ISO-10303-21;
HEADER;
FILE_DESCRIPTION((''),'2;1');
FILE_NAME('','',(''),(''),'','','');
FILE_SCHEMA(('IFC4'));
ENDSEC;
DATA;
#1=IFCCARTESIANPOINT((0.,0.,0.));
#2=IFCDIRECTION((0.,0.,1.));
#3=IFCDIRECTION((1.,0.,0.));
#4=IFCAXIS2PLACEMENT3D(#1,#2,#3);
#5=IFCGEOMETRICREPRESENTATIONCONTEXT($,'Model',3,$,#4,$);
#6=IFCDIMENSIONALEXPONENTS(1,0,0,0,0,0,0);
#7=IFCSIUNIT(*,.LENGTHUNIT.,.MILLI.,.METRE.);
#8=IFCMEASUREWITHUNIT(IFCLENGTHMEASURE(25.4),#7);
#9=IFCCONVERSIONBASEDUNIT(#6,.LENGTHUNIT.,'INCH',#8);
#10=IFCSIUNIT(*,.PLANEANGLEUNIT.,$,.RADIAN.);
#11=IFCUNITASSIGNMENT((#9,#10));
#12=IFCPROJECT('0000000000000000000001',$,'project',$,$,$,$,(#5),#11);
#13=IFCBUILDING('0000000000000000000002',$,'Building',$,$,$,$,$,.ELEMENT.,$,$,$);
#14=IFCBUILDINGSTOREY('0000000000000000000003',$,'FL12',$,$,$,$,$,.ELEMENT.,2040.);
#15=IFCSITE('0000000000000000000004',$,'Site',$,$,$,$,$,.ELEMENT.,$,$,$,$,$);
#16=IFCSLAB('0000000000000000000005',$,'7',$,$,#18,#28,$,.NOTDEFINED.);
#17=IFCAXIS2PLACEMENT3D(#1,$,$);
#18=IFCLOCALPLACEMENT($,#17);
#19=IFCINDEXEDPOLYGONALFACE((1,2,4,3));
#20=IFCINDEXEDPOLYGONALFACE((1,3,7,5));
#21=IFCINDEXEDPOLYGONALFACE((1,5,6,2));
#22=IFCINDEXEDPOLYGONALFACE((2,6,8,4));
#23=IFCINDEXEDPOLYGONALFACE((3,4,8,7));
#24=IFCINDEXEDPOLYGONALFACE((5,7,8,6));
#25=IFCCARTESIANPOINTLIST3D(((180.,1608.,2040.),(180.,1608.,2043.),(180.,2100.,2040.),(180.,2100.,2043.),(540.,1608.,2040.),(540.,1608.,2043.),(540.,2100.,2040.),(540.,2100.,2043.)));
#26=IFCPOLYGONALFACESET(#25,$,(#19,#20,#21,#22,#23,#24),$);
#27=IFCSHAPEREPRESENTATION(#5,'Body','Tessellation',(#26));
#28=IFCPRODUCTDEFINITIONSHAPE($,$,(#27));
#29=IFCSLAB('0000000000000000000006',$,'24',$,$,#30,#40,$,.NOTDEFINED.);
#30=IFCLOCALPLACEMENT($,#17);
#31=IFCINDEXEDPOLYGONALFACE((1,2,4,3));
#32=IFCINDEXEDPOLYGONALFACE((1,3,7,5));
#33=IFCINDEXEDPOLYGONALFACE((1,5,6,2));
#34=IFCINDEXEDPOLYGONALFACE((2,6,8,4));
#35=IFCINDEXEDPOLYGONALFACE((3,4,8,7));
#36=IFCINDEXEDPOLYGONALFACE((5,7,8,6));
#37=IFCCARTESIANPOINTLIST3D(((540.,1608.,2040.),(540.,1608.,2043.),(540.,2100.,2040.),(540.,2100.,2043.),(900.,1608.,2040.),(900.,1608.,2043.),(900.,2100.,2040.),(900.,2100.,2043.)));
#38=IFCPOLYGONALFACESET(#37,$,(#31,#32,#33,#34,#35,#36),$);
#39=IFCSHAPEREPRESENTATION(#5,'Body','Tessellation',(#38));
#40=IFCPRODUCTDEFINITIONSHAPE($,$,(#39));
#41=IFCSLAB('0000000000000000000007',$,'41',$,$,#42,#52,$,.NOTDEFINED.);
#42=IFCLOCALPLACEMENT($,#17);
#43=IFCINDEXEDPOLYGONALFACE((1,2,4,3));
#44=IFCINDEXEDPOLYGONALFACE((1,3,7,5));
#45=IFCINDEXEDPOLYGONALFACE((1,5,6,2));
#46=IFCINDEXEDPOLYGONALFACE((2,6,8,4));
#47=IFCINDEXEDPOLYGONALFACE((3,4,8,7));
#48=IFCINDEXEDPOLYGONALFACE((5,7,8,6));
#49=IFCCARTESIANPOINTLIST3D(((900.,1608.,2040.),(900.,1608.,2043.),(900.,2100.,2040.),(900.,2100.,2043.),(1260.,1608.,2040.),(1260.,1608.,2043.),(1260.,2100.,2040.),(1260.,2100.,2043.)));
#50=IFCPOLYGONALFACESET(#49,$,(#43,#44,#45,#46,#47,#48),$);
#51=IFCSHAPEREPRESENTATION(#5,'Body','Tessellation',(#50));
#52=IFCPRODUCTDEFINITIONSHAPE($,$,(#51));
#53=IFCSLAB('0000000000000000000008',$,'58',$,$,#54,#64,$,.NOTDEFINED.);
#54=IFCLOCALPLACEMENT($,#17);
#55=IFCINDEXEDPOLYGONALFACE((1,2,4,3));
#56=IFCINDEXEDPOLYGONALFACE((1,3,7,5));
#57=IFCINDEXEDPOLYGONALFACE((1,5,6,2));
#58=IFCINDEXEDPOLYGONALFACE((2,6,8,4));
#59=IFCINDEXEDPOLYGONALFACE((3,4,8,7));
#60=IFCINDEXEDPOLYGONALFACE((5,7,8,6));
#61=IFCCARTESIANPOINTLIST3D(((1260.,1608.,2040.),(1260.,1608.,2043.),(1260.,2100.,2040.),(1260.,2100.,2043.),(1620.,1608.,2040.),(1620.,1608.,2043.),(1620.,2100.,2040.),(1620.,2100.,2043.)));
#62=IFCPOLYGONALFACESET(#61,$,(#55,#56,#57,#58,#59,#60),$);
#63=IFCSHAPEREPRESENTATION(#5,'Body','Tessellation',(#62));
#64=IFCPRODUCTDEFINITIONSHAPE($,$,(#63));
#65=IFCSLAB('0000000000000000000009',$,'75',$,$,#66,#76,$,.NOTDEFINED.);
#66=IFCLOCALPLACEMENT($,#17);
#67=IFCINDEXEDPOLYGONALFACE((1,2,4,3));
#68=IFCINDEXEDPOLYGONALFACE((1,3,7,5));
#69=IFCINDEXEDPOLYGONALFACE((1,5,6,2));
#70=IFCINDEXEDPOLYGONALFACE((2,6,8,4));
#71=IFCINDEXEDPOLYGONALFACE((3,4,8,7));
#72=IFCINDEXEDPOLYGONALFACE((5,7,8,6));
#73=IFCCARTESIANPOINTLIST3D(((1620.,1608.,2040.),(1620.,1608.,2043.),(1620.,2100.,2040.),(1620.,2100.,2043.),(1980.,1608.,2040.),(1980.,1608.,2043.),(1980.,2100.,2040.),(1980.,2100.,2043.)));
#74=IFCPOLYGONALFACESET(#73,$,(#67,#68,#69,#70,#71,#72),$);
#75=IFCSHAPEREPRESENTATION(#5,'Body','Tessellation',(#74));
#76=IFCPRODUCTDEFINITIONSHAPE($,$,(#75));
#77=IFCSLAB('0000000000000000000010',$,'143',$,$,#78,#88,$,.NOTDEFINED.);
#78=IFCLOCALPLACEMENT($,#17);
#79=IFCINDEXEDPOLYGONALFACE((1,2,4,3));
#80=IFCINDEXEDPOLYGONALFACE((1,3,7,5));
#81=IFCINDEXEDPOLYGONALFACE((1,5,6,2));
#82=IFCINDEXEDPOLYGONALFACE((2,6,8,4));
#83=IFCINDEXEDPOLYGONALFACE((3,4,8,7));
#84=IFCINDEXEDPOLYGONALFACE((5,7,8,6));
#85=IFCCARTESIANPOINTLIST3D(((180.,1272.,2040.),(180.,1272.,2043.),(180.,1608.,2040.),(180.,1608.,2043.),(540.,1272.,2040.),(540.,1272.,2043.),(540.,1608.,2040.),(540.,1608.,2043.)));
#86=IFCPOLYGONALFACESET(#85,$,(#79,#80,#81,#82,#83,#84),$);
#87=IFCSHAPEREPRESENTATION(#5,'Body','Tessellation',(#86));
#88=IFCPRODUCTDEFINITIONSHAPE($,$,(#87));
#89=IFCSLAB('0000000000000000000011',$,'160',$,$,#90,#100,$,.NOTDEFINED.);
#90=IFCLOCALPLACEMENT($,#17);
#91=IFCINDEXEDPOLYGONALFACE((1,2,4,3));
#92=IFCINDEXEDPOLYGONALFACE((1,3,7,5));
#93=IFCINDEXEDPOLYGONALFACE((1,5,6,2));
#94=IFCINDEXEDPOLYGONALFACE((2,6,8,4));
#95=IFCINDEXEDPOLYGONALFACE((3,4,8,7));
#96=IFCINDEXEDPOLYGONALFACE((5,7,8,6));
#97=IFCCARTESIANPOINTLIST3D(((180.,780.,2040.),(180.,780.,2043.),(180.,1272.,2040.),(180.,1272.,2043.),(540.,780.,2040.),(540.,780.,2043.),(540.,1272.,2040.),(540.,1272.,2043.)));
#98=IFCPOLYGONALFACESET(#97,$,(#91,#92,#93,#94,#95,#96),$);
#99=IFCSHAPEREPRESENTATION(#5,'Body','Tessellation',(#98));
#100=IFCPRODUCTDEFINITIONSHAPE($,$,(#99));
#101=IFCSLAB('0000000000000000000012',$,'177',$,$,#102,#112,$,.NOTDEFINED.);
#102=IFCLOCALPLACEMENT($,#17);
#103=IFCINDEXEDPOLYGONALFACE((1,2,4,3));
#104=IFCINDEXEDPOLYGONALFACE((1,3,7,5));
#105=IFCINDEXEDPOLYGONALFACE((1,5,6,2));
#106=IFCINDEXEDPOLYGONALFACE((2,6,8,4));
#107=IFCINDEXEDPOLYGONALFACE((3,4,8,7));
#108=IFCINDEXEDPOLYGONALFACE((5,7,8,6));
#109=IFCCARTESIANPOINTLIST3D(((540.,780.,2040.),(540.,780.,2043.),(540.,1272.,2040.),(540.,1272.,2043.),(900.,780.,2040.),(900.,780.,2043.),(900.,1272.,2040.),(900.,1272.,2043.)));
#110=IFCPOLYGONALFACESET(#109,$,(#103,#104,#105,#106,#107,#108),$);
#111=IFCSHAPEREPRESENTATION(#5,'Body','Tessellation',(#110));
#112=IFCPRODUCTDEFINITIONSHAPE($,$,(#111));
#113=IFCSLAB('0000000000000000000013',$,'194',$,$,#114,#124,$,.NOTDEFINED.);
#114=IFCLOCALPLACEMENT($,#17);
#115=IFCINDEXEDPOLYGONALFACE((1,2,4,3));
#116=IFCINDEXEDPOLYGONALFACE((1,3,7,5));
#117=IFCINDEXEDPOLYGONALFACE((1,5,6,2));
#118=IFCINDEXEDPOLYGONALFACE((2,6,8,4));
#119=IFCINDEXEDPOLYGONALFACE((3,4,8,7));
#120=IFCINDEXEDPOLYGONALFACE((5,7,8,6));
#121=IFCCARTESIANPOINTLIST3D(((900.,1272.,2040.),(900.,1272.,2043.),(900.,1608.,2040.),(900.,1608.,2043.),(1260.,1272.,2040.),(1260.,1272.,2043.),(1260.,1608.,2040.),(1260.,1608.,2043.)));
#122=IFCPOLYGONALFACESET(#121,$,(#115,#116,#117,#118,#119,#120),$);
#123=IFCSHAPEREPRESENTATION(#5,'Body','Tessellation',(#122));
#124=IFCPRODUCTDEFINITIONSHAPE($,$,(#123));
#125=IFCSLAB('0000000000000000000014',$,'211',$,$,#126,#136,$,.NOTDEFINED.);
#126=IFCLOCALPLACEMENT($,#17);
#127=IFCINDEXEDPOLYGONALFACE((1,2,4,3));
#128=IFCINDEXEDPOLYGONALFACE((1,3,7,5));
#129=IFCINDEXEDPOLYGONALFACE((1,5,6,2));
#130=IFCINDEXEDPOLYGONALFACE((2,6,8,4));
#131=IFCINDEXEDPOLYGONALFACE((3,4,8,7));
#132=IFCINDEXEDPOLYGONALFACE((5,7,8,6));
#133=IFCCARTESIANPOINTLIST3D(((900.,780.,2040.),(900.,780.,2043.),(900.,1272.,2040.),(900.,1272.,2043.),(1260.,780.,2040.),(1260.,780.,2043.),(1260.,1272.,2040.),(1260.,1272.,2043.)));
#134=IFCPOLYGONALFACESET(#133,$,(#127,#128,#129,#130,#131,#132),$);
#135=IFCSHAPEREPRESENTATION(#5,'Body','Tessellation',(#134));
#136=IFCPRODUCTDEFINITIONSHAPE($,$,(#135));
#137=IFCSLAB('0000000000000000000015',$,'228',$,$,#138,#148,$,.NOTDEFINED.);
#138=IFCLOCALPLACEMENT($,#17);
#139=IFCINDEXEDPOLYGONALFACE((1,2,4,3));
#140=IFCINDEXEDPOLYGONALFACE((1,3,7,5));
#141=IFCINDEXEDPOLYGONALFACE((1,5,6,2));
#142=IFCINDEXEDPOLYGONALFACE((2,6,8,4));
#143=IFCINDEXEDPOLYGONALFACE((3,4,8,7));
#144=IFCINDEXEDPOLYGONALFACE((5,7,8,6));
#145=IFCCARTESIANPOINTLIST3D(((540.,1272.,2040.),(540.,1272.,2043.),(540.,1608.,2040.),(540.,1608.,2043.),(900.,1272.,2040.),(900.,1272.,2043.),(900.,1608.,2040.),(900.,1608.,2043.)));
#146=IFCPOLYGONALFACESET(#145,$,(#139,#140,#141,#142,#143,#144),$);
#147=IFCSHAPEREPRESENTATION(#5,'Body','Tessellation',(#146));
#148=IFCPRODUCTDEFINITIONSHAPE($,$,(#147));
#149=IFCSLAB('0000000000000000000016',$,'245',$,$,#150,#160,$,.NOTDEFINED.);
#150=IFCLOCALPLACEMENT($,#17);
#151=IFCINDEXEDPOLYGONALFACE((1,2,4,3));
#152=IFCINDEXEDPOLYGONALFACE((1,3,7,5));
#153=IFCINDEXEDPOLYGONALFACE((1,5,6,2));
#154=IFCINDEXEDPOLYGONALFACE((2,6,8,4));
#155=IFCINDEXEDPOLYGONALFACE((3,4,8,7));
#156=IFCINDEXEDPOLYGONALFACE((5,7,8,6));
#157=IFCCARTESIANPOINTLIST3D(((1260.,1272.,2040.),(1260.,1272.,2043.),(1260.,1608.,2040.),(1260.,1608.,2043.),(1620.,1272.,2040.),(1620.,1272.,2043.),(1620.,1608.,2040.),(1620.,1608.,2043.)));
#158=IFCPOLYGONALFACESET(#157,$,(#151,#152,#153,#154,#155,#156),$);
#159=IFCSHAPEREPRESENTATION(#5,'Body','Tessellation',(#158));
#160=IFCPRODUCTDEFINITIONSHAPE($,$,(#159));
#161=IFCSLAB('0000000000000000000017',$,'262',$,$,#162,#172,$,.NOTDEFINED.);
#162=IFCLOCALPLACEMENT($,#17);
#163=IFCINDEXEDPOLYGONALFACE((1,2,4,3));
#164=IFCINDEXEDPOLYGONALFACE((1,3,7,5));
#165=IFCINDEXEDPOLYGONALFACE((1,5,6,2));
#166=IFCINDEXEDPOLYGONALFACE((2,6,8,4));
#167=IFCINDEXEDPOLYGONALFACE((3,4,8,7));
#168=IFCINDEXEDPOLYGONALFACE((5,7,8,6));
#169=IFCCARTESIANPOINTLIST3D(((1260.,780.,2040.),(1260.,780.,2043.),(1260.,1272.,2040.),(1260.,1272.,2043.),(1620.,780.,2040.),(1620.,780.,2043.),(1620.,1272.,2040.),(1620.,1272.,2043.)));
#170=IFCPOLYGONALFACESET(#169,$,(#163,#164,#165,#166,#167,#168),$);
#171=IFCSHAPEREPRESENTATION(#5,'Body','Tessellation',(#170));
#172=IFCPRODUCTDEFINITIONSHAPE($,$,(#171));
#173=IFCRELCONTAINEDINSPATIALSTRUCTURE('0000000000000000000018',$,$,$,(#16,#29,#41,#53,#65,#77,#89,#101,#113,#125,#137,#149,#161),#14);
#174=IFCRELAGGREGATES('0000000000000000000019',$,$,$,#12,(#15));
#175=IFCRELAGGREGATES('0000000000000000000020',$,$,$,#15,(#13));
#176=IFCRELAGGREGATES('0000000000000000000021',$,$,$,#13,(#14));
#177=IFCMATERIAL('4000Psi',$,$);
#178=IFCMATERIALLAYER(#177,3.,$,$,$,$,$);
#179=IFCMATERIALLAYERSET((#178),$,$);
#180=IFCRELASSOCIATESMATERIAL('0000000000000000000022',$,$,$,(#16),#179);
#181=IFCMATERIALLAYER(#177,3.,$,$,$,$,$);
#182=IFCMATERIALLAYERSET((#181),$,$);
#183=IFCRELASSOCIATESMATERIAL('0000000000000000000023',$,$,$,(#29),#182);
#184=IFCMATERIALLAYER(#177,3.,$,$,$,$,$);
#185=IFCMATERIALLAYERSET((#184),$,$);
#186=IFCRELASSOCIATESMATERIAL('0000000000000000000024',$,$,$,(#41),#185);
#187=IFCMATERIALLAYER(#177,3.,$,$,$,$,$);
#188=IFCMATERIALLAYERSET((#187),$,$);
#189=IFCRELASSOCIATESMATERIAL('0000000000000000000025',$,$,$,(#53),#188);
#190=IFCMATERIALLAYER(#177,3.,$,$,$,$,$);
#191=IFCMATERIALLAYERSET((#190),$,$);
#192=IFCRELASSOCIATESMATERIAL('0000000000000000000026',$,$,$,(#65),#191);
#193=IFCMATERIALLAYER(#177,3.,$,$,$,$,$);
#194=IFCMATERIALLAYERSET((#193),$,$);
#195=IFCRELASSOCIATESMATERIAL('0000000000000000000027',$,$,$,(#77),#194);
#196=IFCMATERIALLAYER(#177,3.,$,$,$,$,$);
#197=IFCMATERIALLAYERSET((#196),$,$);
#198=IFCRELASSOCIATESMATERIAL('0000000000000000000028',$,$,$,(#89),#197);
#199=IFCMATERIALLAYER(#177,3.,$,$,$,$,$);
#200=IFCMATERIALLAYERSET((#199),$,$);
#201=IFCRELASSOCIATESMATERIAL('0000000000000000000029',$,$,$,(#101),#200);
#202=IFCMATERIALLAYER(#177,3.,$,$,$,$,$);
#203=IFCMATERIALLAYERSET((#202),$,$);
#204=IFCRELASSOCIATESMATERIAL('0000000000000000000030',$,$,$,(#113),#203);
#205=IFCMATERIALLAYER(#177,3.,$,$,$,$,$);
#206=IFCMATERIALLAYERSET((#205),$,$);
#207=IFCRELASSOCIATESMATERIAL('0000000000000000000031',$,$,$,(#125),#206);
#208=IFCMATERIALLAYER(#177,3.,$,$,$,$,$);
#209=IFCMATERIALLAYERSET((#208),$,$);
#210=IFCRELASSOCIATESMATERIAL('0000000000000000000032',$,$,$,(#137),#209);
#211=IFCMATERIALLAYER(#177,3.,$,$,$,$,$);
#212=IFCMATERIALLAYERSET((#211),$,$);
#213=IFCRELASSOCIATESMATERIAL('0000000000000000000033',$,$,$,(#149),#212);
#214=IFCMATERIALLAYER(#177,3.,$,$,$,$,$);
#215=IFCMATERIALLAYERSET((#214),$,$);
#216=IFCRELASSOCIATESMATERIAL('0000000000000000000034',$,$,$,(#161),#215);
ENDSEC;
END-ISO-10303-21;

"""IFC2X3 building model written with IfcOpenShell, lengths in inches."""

from ifc_helpers import new_model, entity, si_unit, converted_unit, frame, origin_with_axes, place, context, project, spatial, polyline, outline, extrude, material, layer, layer_set, layer_usage, element, save


model = new_model("IFC2X3")

# Units and contexts
model_context = context("Model", 3, world=origin_with_axes())
ifc_project = project(units=[converted_unit("LENGTHUNIT", "INCH", entity("IfcLengthMeasure", 25.4), si_unit("LENGTHUNIT", "METRE", prefix="MILLI"), dimensions=[1, 0, 0, 0, 0, 0, 0]), si_unit("PLANEANGLEUNIT", "RADIAN")], contexts=[model_context])

# Site, building, storey
site = spatial("IfcSite", under=ifc_project, Name="Site", CompositionType="ELEMENT")
building = spatial("IfcBuilding", under=site, Name="Building", CompositionType="ELEMENT")
storey = spatial("IfcBuildingStorey", under=building, Name="FL12", CompositionType="ELEMENT", Elevation=2040.0)

# Slabs
ifc_material_1 = material(Name="4000Psi")
ifc_layer_1 = layer(ifc_material_1, 3.0)
ifc_layer_set_1 = layer_set([ifc_layer_1])
ifc_layer_usage_1 = layer_usage(ifc_layer_set_1, "AXIS2", "POSITIVE", -3.0)
slab_1_placement = place(None, frame((180.0, 1608.0, 2040.0), z_axis=(0.0, 0.0, 1.0), x_axis=(1.0, 0.0, 0.0)))
element("IfcSlab", 1, at=slab_1_placement, inside=storey, material=ifc_layer_usage_1, Name="7", PredefinedType="NOTDEFINED", context=model_context, shape_type="SweptSolid", body=[
    extrude(outline(polyline([(0.0, 0.0), (360.0, 0.0), (360.0, 492.0), (0.0, 492.0), (0.0, 0.0)])), origin_with_axes(), (0.0, 0.0, 1.0), 3.0),
])
ifc_layer_2 = layer(ifc_material_1, 3.0)
ifc_layer_set_2 = layer_set([ifc_layer_2])
ifc_layer_usage_2 = layer_usage(ifc_layer_set_2, "AXIS2", "POSITIVE", -3.0)
slab_2_placement = place(None, frame((540.0, 1608.0, 2040.0), z_axis=(0.0, 0.0, 1.0), x_axis=(1.0, 0.0, 0.0)))
element("IfcSlab", 2, at=slab_2_placement, inside=storey, material=ifc_layer_usage_2, Name="24", PredefinedType="NOTDEFINED", context=model_context, shape_type="SweptSolid", body=[
    extrude(outline(polyline([(0.0, 0.0), (360.0, 0.0), (360.0, 492.0), (0.0, 492.0), (0.0, 0.0)])), origin_with_axes(), (0.0, 0.0, 1.0), 3.0),
])
ifc_layer_3 = layer(ifc_material_1, 3.0)
ifc_layer_set_3 = layer_set([ifc_layer_3])
ifc_layer_usage_3 = layer_usage(ifc_layer_set_3, "AXIS2", "POSITIVE", -3.0)
slab_3_placement = place(None, frame((900.0, 1608.0, 2040.0), z_axis=(0.0, 0.0, 1.0), x_axis=(1.0, 0.0, 0.0)))
element("IfcSlab", 3, at=slab_3_placement, inside=storey, material=ifc_layer_usage_3, Name="41", PredefinedType="NOTDEFINED", context=model_context, shape_type="SweptSolid", body=[
    extrude(outline(polyline([(0.0, 0.0), (360.0, 0.0), (360.0, 492.0), (0.0, 492.0), (0.0, 0.0)])), origin_with_axes(), (0.0, 0.0, 1.0), 3.0),
])
ifc_layer_4 = layer(ifc_material_1, 3.0)
ifc_layer_set_4 = layer_set([ifc_layer_4])
ifc_layer_usage_4 = layer_usage(ifc_layer_set_4, "AXIS2", "POSITIVE", -3.0)
slab_4_placement = place(None, frame((1260.0, 1608.0, 2040.0), z_axis=(0.0, 0.0, 1.0), x_axis=(1.0, 0.0, 0.0)))
element("IfcSlab", 4, at=slab_4_placement, inside=storey, material=ifc_layer_usage_4, Name="58", PredefinedType="NOTDEFINED", context=model_context, shape_type="SweptSolid", body=[
    extrude(outline(polyline([(0.0, 0.0), (360.0, 0.0), (360.0, 492.0), (0.0, 492.0), (0.0, 0.0)])), origin_with_axes(), (0.0, 0.0, 1.0), 3.0),
])
ifc_layer_5 = layer(ifc_material_1, 3.0)
ifc_layer_set_5 = layer_set([ifc_layer_5])
ifc_layer_usage_5 = layer_usage(ifc_layer_set_5, "AXIS2", "POSITIVE", -3.0)
slab_5_placement = place(None, frame((1620.0, 1608.0, 2040.0), z_axis=(0.0, 0.0, 1.0), x_axis=(1.0, 0.0, 0.0)))
element("IfcSlab", 5, at=slab_5_placement, inside=storey, material=ifc_layer_usage_5, Name="75", PredefinedType="NOTDEFINED", context=model_context, shape_type="SweptSolid", body=[
    extrude(outline(polyline([(0.0, 0.0), (360.0, 0.0), (360.0, 492.0), (0.0, 492.0), (0.0, 0.0)])), origin_with_axes(), (0.0, 0.0, 1.0), 3.0),
])
ifc_layer_6 = layer(ifc_material_1, 3.0)
ifc_layer_set_6 = layer_set([ifc_layer_6])
ifc_layer_usage_6 = layer_usage(ifc_layer_set_6, "AXIS2", "POSITIVE", -3.0)
slab_6_placement = place(None, frame((180.0, 1272.0, 2040.0), z_axis=(0.0, 0.0, 1.0), x_axis=(1.0, 0.0, 0.0)))
element("IfcSlab", 6, at=slab_6_placement, inside=storey, material=ifc_layer_usage_6, Name="143", PredefinedType="NOTDEFINED", context=model_context, shape_type="SweptSolid", body=[
    extrude(outline(polyline([(0.0, 0.0), (360.0, 0.0), (360.0, 336.0), (0.0, 336.0), (0.0, 0.0)])), origin_with_axes(), (0.0, 0.0, 1.0), 3.0),
])
ifc_layer_7 = layer(ifc_material_1, 3.0)
ifc_layer_set_7 = layer_set([ifc_layer_7])
ifc_layer_usage_7 = layer_usage(ifc_layer_set_7, "AXIS2", "POSITIVE", -3.0)
slab_7_placement = place(None, frame((180.0, 780.0, 2040.0), z_axis=(0.0, 0.0, 1.0), x_axis=(1.0, 0.0, 0.0)))
element("IfcSlab", 7, at=slab_7_placement, inside=storey, material=ifc_layer_usage_7, Name="160", PredefinedType="NOTDEFINED", context=model_context, shape_type="SweptSolid", body=[
    extrude(outline(polyline([(0.0, 0.0), (360.0, 0.0), (360.0, 492.0), (0.0, 492.0), (0.0, 0.0)])), origin_with_axes(), (0.0, 0.0, 1.0), 3.0),
])
ifc_layer_8 = layer(ifc_material_1, 3.0)
ifc_layer_set_8 = layer_set([ifc_layer_8])
ifc_layer_usage_8 = layer_usage(ifc_layer_set_8, "AXIS2", "POSITIVE", -3.0)
slab_8_placement = place(None, frame((540.0, 780.0, 2040.0), z_axis=(0.0, 0.0, 1.0), x_axis=(1.0, 0.0, 0.0)))
element("IfcSlab", 8, at=slab_8_placement, inside=storey, material=ifc_layer_usage_8, Name="177", PredefinedType="NOTDEFINED", context=model_context, shape_type="SweptSolid", body=[
    extrude(outline(polyline([(0.0, 0.0), (360.0, 0.0), (360.0, 492.0), (0.0, 492.0), (0.0, 0.0)])), origin_with_axes(), (0.0, 0.0, 1.0), 3.0),
])
ifc_layer_9 = layer(ifc_material_1, 3.0)
ifc_layer_set_9 = layer_set([ifc_layer_9])
ifc_layer_usage_9 = layer_usage(ifc_layer_set_9, "AXIS2", "POSITIVE", -3.0)
slab_9_placement = place(None, frame((900.0, 1272.0, 2040.0), z_axis=(0.0, 0.0, 1.0), x_axis=(1.0, 0.0, 0.0)))
element("IfcSlab", 9, at=slab_9_placement, inside=storey, material=ifc_layer_usage_9, Name="194", PredefinedType="NOTDEFINED", context=model_context, shape_type="SweptSolid", body=[
    extrude(outline(polyline([(0.0, 0.0), (360.0, 0.0), (360.0, 336.0), (0.0, 336.0), (0.0, 0.0)])), origin_with_axes(), (0.0, 0.0, 1.0), 3.0),
])
ifc_layer_10 = layer(ifc_material_1, 3.0)
ifc_layer_set_10 = layer_set([ifc_layer_10])
ifc_layer_usage_10 = layer_usage(ifc_layer_set_10, "AXIS2", "POSITIVE", -3.0)
slab_10_placement = place(None, frame((900.0, 780.0, 2040.0), z_axis=(0.0, 0.0, 1.0), x_axis=(1.0, 0.0, 0.0)))
element("IfcSlab", 10, at=slab_10_placement, inside=storey, material=ifc_layer_usage_10, Name="211", PredefinedType="NOTDEFINED", context=model_context, shape_type="SweptSolid", body=[
    extrude(outline(polyline([(0.0, 0.0), (360.0, 0.0), (360.0, 492.0), (0.0, 492.0), (0.0, 0.0)])), origin_with_axes(), (0.0, 0.0, 1.0), 3.0),
])
ifc_layer_11 = layer(ifc_material_1, 3.0)
ifc_layer_set_11 = layer_set([ifc_layer_11])
ifc_layer_usage_11 = layer_usage(ifc_layer_set_11, "AXIS2", "POSITIVE", -3.0)
slab_11_placement = place(None, frame((540.0, 1272.0, 2040.0), z_axis=(0.0, 0.0, 1.0), x_axis=(1.0, 0.0, 0.0)))
element("IfcSlab", 11, at=slab_11_placement, inside=storey, material=ifc_layer_usage_11, Name="228", PredefinedType="NOTDEFINED", context=model_context, shape_type="SweptSolid", body=[
    extrude(outline(polyline([(0.0, 0.0), (360.0, 0.0), (360.0, 336.0), (0.0, 336.0), (0.0, 0.0)])), origin_with_axes(), (0.0, 0.0, 1.0), 3.0),
])
ifc_layer_12 = layer(ifc_material_1, 3.0)
ifc_layer_set_12 = layer_set([ifc_layer_12])
ifc_layer_usage_12 = layer_usage(ifc_layer_set_12, "AXIS2", "POSITIVE", -3.0)
slab_12_placement = place(None, frame((1260.0, 1272.0, 2040.0), z_axis=(0.0, 0.0, 1.0), x_axis=(1.0, 0.0, 0.0)))
element("IfcSlab", 12, at=slab_12_placement, inside=storey, material=ifc_layer_usage_12, Name="245", PredefinedType="NOTDEFINED", context=model_context, shape_type="SweptSolid", body=[
    extrude(outline(polyline([(0.0, 0.0), (360.0, 0.0), (360.0, 336.0), (0.0, 336.0), (0.0, 0.0)])), origin_with_axes(), (0.0, 0.0, 1.0), 3.0),
])
ifc_layer_13 = layer(ifc_material_1, 3.0)
ifc_layer_set_13 = layer_set([ifc_layer_13])
ifc_layer_usage_13 = layer_usage(ifc_layer_set_13, "AXIS2", "POSITIVE", -3.0)
slab_13_placement = place(None, frame((1260.0, 780.0, 2040.0), z_axis=(0.0, 0.0, 1.0), x_axis=(1.0, 0.0, 0.0)))
element("IfcSlab", 13, at=slab_13_placement, inside=storey, material=ifc_layer_usage_13, Name="262", PredefinedType="NOTDEFINED", context=model_context, shape_type="SweptSolid", body=[
    extrude(outline(polyline([(0.0, 0.0), (360.0, 0.0), (360.0, 492.0), (0.0, 492.0), (0.0, 0.0)])), origin_with_axes(), (0.0, 0.0, 1.0), 3.0),
])

save(model, "model.ifc")
